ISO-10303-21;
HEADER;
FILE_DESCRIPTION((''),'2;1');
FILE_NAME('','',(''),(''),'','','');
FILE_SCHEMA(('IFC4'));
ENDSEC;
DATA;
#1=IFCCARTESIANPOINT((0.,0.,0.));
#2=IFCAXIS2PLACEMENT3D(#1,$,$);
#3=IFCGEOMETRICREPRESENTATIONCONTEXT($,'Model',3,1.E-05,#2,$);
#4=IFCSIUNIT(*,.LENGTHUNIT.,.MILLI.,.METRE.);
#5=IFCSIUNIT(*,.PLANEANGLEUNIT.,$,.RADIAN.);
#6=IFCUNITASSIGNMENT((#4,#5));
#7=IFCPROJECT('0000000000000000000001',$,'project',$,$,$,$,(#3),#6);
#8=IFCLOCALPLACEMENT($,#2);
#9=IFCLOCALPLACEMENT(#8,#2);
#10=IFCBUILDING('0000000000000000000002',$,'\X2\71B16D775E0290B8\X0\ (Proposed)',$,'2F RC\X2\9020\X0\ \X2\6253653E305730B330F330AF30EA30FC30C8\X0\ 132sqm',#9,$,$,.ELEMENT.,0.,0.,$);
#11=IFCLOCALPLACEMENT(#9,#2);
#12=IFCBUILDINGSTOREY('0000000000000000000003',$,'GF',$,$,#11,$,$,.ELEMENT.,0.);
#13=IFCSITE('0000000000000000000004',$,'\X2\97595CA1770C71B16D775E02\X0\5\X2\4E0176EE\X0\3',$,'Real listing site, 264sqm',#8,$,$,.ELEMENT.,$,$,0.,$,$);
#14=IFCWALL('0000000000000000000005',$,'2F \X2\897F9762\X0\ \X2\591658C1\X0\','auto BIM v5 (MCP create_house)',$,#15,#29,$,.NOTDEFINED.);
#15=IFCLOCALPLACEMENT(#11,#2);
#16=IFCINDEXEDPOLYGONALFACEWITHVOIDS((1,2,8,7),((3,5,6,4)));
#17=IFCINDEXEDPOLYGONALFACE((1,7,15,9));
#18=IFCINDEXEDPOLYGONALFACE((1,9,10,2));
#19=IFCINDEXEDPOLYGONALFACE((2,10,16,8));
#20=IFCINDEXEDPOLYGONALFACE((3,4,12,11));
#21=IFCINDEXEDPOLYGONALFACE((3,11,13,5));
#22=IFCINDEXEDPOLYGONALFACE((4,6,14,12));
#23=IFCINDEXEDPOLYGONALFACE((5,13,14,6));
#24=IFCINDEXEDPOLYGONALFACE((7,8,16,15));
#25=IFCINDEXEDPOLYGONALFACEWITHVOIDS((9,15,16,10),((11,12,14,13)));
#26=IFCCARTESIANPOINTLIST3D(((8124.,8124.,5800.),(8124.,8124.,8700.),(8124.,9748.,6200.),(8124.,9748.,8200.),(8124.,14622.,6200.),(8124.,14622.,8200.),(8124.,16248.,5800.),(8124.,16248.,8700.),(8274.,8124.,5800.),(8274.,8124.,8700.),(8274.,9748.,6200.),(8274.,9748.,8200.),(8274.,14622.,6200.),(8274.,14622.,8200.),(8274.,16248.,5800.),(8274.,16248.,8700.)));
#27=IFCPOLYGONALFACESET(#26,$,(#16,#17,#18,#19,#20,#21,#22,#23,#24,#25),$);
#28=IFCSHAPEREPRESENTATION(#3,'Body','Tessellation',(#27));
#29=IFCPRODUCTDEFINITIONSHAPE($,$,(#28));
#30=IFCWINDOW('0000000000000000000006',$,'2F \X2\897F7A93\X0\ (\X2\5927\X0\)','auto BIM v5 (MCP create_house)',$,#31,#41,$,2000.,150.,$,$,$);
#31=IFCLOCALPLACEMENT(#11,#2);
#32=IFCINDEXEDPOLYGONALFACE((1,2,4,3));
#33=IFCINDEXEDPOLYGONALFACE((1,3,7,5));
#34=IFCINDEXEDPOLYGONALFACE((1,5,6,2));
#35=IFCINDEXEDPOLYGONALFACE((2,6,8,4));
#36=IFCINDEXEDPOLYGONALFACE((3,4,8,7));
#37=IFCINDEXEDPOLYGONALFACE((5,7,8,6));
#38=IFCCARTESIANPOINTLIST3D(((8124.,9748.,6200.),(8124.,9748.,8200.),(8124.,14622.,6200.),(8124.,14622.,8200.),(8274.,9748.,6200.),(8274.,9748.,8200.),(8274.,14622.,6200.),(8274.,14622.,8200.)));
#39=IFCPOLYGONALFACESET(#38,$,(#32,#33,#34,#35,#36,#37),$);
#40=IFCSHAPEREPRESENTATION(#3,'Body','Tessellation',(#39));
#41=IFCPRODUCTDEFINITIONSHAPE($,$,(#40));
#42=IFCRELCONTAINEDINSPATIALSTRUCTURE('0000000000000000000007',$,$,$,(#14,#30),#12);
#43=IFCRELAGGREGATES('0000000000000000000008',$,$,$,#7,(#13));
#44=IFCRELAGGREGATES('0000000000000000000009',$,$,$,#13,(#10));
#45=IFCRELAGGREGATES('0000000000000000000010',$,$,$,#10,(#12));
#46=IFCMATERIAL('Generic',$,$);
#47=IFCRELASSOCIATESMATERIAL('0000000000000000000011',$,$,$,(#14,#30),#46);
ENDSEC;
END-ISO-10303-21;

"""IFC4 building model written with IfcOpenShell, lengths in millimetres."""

from ifc_helpers import new_model, si_unit, frame, frame_2d, origin, place, context, project, spatial, rectangle, extrude, material, element, fill, save


model = new_model("IFC4")

# Units and contexts
model_context = context("Model", 3, precision=1e-05, world=origin())
ifc_project = project(units=[si_unit("LENGTHUNIT", "METRE", prefix="MILLI"), si_unit("PLANEANGLEUNIT", "RADIAN")], contexts=[model_context])

# Site, building, storey
site_placement = place(None, origin())
site = spatial("IfcSite", under=ifc_project, at=site_placement, Name="静岡県熱海市5丁目3", ObjectType="Real listing site, 264sqm", CompositionType="ELEMENT", RefElevation=0.0)
building_placement = place(site_placement, origin())
building = spatial("IfcBuilding", under=site, at=building_placement, Name="熱海市邸 (Proposed)", ObjectType="2F RC造 打放しコンクリート 132sqm", CompositionType="ELEMENT", ElevationOfRefHeight=0.0, ElevationOfTerrain=0.0)
storey_placement = place(building_placement, origin())
storey = spatial("IfcBuildingStorey", under=building, at=storey_placement, Name="GF", CompositionType="ELEMENT", Elevation=0.0)

# Shared definitions
ifc_material = material(Name="Generic")

# Wall, opening, window
wall_1_placement = place(storey_placement, frame((4062.0, 4062.0, 2900.0)))
wall_1 = element("IfcWall", 1, at=wall_1_placement, inside=storey, material=ifc_material, Name="2F 西面 外壁", Description="auto BIM v5 (MCP create_house)", PredefinedType="NOTDEFINED", context=model_context, shape_type="SweptSolid", body=[
    extrude(rectangle(XDim=150.0, YDim=8124.0, at=frame_2d((75.0, 4062.0))), frame((4062.0, 4062.0, 2900.0)), (0.0, 0.0, 1.0), 2900.0),
])
opening_1_placement = place(storey_placement, frame((4062.0, 4874.0, 3100.0)))
opening_1 = element("IfcOpeningElement", 2, at=opening_1_placement, cuts=wall_1, PredefinedType="NOTDEFINED", context=model_context, shape_type="SweptSolid", body=[
    extrude(rectangle(XDim=150.0, YDim=4874.0, at=frame_2d((75.0, 2437.0))), frame((4062.0, 4874.0, 3100.0)), (0.0, 0.0, 1.0), 2000.0),
])
window_1_placement = place(storey_placement, frame((4062.0, 4874.0, 3100.0)))
window_1 = element("IfcWindow", 3, at=window_1_placement, inside=storey, material=ifc_material, Name="2F 西窓 (大)", Description="auto BIM v5 (MCP create_house)", OverallHeight=2000.0, OverallWidth=150.0, context=model_context, shape_type="SweptSolid", body=[
    extrude(rectangle(XDim=150.0, YDim=4874.0, at=frame_2d((75.0, 2437.0))), frame((4062.0, 4874.0, 3100.0)), (0.0, 0.0, 1.0), 2000.0),
])
fill(opening_1, window_1)

save(model, "model.ifc")
